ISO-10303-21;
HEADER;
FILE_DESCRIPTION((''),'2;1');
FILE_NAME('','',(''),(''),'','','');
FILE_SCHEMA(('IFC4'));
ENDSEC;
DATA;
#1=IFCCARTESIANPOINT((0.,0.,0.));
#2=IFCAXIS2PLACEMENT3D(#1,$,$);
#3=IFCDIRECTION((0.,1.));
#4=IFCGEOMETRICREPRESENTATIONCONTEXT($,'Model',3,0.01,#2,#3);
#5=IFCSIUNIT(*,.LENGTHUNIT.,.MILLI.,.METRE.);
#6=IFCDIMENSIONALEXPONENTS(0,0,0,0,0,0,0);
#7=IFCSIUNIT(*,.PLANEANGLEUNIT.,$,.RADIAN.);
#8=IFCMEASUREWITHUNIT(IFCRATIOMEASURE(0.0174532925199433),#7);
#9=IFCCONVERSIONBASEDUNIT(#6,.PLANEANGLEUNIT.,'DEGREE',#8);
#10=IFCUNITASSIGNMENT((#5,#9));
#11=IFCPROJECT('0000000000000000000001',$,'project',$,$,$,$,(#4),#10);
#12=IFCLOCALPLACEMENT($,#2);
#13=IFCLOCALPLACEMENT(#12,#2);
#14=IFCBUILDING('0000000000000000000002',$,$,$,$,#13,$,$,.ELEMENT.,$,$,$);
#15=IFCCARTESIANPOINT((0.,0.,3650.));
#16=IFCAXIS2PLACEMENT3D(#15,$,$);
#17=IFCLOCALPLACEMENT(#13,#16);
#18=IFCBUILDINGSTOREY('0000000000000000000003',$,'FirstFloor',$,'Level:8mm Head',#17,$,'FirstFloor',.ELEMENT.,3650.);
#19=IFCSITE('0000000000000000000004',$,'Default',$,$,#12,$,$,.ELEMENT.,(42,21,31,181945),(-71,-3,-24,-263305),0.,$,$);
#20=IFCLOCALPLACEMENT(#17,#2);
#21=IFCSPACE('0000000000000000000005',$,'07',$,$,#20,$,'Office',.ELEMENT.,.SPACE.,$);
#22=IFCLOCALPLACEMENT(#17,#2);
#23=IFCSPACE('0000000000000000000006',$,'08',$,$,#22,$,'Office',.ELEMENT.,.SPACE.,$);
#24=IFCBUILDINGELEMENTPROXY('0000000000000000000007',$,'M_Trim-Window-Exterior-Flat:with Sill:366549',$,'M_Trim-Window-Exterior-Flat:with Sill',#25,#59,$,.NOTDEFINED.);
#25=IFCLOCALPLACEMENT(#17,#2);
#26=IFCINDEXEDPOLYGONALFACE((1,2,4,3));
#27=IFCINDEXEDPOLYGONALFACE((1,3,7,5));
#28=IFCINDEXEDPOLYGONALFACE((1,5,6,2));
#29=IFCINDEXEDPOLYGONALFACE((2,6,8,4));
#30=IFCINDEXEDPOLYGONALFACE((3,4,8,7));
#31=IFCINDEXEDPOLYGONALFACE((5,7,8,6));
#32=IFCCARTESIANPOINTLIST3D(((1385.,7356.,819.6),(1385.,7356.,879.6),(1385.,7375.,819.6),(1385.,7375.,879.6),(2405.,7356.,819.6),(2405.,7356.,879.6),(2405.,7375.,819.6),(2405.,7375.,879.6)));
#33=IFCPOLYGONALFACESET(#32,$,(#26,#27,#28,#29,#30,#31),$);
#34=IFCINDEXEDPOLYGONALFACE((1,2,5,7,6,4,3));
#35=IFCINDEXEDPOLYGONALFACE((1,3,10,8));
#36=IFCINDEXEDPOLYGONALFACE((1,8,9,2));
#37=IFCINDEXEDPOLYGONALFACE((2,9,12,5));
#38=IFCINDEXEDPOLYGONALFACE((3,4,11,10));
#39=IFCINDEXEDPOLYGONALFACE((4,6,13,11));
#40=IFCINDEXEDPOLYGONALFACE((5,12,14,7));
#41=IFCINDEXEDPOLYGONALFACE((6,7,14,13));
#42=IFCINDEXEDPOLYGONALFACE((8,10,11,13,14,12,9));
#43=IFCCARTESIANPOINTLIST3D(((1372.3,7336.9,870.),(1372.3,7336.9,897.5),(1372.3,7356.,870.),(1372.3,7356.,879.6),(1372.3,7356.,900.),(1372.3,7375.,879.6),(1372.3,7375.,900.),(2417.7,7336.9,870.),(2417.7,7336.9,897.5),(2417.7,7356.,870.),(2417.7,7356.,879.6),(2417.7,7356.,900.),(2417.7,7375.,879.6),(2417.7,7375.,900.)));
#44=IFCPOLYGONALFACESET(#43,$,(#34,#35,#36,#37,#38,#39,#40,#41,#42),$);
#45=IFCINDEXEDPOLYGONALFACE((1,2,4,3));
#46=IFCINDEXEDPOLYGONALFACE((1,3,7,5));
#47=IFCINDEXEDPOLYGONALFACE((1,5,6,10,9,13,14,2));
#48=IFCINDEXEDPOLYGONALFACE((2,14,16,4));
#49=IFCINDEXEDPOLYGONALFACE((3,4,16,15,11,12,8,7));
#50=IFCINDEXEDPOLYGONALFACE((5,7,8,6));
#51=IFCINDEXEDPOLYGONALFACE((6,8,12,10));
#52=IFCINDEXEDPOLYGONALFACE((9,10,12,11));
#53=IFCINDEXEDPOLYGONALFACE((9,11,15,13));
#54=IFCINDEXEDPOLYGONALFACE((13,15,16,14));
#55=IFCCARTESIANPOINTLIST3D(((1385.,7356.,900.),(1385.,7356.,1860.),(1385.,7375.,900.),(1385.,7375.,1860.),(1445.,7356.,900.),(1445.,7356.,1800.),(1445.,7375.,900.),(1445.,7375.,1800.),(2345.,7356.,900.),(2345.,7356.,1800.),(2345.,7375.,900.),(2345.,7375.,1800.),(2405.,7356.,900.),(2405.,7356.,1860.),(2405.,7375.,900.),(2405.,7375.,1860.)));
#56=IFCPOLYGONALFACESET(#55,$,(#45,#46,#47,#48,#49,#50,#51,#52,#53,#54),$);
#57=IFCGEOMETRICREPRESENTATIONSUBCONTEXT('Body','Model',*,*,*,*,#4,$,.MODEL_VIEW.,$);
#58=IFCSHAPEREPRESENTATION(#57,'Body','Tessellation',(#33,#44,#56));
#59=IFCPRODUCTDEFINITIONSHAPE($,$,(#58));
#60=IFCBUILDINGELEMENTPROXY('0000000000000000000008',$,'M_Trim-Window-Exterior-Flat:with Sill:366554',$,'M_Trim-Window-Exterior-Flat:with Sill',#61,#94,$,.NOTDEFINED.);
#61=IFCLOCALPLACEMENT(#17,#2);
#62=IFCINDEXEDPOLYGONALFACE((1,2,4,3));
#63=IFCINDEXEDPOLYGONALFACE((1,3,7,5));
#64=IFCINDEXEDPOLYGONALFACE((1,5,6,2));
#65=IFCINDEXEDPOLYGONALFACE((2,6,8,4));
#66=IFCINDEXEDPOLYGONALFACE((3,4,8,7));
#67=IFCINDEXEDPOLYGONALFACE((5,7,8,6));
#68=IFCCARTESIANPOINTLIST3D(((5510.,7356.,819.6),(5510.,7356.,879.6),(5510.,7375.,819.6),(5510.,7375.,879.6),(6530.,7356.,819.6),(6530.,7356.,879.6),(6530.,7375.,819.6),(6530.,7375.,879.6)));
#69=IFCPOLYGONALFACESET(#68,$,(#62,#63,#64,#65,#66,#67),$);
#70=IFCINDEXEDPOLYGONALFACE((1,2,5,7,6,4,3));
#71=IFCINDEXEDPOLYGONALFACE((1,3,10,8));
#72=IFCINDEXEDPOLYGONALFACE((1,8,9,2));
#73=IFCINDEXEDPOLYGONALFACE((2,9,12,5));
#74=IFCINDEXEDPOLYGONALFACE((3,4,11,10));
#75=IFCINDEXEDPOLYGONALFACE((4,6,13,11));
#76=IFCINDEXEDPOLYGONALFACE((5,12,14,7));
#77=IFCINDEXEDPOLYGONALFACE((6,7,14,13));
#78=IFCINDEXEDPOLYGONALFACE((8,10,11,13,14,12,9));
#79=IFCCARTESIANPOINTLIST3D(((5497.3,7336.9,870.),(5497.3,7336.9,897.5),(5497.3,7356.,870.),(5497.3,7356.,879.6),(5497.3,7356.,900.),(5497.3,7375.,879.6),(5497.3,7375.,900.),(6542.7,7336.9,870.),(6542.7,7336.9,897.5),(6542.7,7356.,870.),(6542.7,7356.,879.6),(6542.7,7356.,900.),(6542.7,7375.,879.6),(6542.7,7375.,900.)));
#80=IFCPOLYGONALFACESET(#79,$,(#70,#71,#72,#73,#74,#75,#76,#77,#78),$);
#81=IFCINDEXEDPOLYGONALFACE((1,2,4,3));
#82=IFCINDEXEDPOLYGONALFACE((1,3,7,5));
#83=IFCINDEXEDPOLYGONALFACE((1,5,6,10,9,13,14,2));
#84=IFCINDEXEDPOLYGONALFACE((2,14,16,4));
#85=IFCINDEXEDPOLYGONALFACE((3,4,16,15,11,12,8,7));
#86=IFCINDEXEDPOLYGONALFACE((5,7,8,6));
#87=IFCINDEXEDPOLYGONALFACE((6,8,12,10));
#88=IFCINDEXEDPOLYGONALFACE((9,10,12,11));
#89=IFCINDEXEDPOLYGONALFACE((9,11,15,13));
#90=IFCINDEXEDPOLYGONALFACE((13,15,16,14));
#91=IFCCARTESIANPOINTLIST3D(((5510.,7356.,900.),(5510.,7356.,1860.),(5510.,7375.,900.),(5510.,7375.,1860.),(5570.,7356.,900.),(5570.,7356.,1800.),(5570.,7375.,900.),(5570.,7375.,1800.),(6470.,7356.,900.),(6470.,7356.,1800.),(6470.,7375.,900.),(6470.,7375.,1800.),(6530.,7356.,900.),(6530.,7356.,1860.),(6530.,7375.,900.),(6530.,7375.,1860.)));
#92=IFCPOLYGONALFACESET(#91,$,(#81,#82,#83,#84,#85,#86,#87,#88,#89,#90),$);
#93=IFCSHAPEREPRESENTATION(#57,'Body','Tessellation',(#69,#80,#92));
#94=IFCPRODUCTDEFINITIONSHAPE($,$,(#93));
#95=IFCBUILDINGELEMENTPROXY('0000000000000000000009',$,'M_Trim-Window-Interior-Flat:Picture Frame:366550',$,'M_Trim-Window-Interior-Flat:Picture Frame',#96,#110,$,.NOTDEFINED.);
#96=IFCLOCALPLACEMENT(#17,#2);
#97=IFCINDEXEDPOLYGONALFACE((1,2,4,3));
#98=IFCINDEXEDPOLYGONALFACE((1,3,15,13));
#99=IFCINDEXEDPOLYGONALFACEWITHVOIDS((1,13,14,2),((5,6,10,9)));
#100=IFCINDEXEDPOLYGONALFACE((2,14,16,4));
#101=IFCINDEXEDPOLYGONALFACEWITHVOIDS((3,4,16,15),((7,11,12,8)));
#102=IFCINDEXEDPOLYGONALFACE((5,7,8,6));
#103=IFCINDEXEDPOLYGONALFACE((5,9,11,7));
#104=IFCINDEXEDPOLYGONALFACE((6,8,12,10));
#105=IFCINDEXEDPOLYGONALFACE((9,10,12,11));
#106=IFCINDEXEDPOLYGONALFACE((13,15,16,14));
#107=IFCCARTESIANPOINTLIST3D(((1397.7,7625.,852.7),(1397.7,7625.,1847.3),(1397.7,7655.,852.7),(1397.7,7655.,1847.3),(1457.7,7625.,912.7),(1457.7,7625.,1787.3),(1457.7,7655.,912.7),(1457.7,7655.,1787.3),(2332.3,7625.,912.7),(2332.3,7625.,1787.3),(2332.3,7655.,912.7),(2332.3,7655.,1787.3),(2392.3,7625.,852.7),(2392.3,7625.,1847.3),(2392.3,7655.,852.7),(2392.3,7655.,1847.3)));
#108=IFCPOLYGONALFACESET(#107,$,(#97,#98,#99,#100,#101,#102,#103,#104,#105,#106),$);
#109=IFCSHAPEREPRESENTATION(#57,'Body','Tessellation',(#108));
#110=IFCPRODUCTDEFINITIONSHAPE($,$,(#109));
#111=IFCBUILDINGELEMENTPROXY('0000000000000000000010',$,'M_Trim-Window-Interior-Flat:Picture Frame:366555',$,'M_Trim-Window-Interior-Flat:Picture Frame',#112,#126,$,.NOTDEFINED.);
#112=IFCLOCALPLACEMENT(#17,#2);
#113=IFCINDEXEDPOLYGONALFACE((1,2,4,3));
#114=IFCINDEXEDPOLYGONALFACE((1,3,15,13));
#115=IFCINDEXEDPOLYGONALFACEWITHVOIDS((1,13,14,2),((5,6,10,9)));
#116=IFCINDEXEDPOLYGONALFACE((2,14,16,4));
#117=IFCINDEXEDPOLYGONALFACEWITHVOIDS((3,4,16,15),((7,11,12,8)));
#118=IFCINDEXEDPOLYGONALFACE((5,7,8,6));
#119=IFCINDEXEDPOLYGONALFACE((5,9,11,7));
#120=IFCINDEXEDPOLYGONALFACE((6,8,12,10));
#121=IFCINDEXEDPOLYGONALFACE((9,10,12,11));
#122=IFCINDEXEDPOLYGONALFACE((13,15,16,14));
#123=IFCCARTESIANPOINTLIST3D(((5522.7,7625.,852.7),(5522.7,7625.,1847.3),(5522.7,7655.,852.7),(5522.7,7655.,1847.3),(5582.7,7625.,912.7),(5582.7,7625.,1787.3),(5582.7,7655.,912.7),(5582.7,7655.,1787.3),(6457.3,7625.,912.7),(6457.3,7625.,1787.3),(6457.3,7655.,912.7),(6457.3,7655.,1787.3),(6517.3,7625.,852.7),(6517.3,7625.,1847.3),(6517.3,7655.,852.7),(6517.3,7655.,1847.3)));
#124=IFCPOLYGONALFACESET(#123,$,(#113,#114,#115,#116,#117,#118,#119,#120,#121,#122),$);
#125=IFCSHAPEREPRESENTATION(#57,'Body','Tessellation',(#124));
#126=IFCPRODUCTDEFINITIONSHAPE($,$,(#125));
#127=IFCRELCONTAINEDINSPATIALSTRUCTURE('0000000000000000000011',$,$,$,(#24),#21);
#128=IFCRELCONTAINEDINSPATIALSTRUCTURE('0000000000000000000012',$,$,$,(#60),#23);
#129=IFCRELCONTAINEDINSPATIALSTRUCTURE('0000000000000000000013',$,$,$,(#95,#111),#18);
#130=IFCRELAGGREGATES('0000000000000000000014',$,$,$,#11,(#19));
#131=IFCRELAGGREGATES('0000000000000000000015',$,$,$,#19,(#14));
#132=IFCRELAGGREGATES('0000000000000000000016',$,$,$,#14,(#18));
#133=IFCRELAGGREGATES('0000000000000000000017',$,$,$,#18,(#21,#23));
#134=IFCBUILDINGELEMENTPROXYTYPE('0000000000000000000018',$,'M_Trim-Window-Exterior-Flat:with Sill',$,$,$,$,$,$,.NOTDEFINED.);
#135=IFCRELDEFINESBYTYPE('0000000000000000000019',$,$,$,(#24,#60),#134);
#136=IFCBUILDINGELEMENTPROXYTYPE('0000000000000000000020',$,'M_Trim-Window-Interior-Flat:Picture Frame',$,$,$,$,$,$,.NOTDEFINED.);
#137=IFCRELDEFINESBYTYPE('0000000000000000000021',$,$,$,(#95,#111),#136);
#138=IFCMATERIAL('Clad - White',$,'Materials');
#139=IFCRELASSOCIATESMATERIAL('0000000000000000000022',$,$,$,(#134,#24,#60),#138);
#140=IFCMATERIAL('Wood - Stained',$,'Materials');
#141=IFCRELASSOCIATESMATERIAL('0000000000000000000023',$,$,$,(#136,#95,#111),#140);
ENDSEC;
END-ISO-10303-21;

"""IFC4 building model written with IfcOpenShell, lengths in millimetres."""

from ifc_helpers import new_model, entity, si_unit, converted_unit, direction, frame, frame_2d, origin, place, context, subcontext, project, spatial, polyline, rectangle, outline, extrude, source, transform, mapped, material, type_object, type_shapes, element, save


model = new_model("IFC4")

# Units and contexts
model_context = context("Model", 3, precision=0.01, world=origin(), true_north=direction((0.0, 1.0)))
body_context = subcontext(model_context, "Body", "Model", "MODEL_VIEW")
ifc_project = project(units=[si_unit("LENGTHUNIT", "METRE", prefix="MILLI"), converted_unit("PLANEANGLEUNIT", "DEGREE", entity("IfcRatioMeasure", 0.0174532925199433), si_unit("PLANEANGLEUNIT", "RADIAN"), dimensions=[0, 0, 0, 0, 0, 0, 0])], contexts=[model_context])

# Site, building, storey
site_placement = place(None, origin())
site = spatial("IfcSite", under=ifc_project, at=site_placement, Name="Default", CompositionType="ELEMENT", RefLatitude=(42, 21, 31, 181945), RefLongitude=(-71, -3, -24, -263305), RefElevation=0.0)
building_placement = place(site_placement, origin())
building = spatial("IfcBuilding", under=site, at=building_placement, CompositionType="ELEMENT")
storey_placement = place(building_placement, frame((0.0, 0.0, 3650.0)))
storey = spatial("IfcBuildingStorey", under=building, at=storey_placement, Name="FirstFloor", ObjectType="Level:8mm Head", LongName="FirstFloor", CompositionType="ELEMENT", Elevation=3650.0)

# Shared definitions
ifc_material_1 = material(Name="Clad - White", Category="Materials")
ifc_material_2 = material(Name="Wood - Stained", Category="Materials")

# Shared definitions
space_1_placement = place(storey_placement, origin())
space_1 = spatial("IfcSpace", under=storey, at=space_1_placement, Name="07", LongName="Office", CompositionType="ELEMENT", PredefinedType="SPACE")

# Building element proxy
building_element_proxy_type_1 = type_object("IfcBuildingElementProxyType", Name="M_Trim-Window-Exterior-Flat:with Sill", PredefinedType="NOTDEFINED", material=ifc_material_1)
shared_shape_1 = source(origin(), body_context, "Body", "SweptSolid", [
    extrude(rectangle(XDim=1020.0, YDim=60.0, at=frame_2d((0.0, 0.0), x_axis=(1.0, 0.0))), frame((0.0, -950.4, 0.0), z_axis=(0.0, 0.0, 1.0), x_axis=(-1.0, 0.0, 0.0)), (0.0, 0.0, 1.0), 19.1),
    extrude(outline(polyline([(-19.0, -15.2), (0.0, -15.2), (0.0, -5.7), (19.0, -5.7), (19.0, 14.8), (0.0, 14.8), (-19.0, 12.3), (-19.0, -15.2)])), frame((-522.7, -914.8, 19.0), z_axis=(1.0, 0.0, 0.0), x_axis=(0.0, 0.0, -1.0)), (0.0, 0.0, 1.0), 1045.4),
    extrude(outline(polyline([(-495.0, -510.0), (465.0, -510.0), (465.0, -450.0), (-435.0, -450.0), (-435.0, 450.0), (465.0, 450.0), (465.0, 510.0), (-495.0, 510.0), (-495.0, -510.0)])), frame((0.0, -435.0, 0.0), z_axis=(0.0, 0.0, 1.0), x_axis=(0.0, -1.0, 0.0)), (0.0, 0.0, 1.0), 19.1),
])
type_shapes(building_element_proxy_type_1, [shared_shape_1])
proxy_1_placement = place(space_1_placement, frame((1895.0, 7375.0, 1800.0), z_axis=(0.0, -1.0, 0.0), x_axis=(1.0, 0.0, 0.0)))
element("IfcBuildingElementProxy", 1, at=proxy_1_placement, inside=space_1, type_object=building_element_proxy_type_1, material=ifc_material_1, Name="M_Trim-Window-Exterior-Flat:with Sill:366549", ObjectType="M_Trim-Window-Exterior-Flat:with Sill", PredefinedType="NOTDEFINED", context=body_context, shape_type="MappedRepresentation", body=[
    mapped(shared_shape_1, transform((0.0, 0.0, 0.0), scale=1.0)),
])

# Shared definitions
space_2_placement = place(storey_placement, origin())
space_2 = spatial("IfcSpace", under=storey, at=space_2_placement, Name="08", LongName="Office", CompositionType="ELEMENT", PredefinedType="SPACE")

# Building element proxies
proxy_2_placement = place(space_2_placement, frame((6020.0, 7375.0, 1800.0), z_axis=(0.0, -1.0, 0.0), x_axis=(1.0, 0.0, 0.0)))
element("IfcBuildingElementProxy", 2, at=proxy_2_placement, inside=space_2, type_object=building_element_proxy_type_1, material=ifc_material_1, Name="M_Trim-Window-Exterior-Flat:with Sill:366554", ObjectType="M_Trim-Window-Exterior-Flat:with Sill", PredefinedType="NOTDEFINED", context=body_context, shape_type="MappedRepresentation", body=[
    mapped(shared_shape_1, transform((0.0, 0.0, 0.0), scale=1.0)),
])
building_element_proxy_type_2 = type_object("IfcBuildingElementProxyType", Name="M_Trim-Window-Interior-Flat:Picture Frame", PredefinedType="NOTDEFINED", material=ifc_material_2)
shared_shape_2 = source(origin(), body_context, "Body", "SweptSolid", [
    extrude(outline(polyline([(-497.3, -497.3), (497.3, -497.3), (497.3, 497.3), (-497.3, 497.3), (-497.3, -497.3)]), holes=[polyline([(-437.3, -437.3), (-437.3, 437.3), (437.3, 437.3), (437.3, -437.3), (-437.3, -437.3)])]), frame((0.0, -450.0, 0.0), z_axis=(0.0, 0.0, 1.0), x_axis=(-1.0, 0.0, 0.0)), (0.0, 0.0, 1.0), 30.0),
])
type_shapes(building_element_proxy_type_2, [shared_shape_2])
for number, where, z_axis, x_axis, name in (
    (3, (1895.0, 7625.0, 1800.0), (0.0, 1.0, 0.0), (-1.0, 0.0, 0.0), "M_Trim-Window-Interior-Flat:Picture Frame:366550"),
    (4, (6020.0, 7625.0, 1800.0), (0.0, 1.0, 0.0), (-1.0, 0.0, 0.0), "M_Trim-Window-Interior-Flat:Picture Frame:366555"),
):
    element("IfcBuildingElementProxy", number, at=place(storey_placement, frame(where, z_axis=z_axis, x_axis=x_axis)), inside=storey, type_object=building_element_proxy_type_2, material=ifc_material_2, Name=name, ObjectType="M_Trim-Window-Interior-Flat:Picture Frame", PredefinedType="NOTDEFINED", context=body_context, shape_type="MappedRepresentation", body=[
        mapped(shared_shape_2, transform((0.0, 0.0, 0.0), scale=1.0)),
    ])

save(model, "model.ifc")
